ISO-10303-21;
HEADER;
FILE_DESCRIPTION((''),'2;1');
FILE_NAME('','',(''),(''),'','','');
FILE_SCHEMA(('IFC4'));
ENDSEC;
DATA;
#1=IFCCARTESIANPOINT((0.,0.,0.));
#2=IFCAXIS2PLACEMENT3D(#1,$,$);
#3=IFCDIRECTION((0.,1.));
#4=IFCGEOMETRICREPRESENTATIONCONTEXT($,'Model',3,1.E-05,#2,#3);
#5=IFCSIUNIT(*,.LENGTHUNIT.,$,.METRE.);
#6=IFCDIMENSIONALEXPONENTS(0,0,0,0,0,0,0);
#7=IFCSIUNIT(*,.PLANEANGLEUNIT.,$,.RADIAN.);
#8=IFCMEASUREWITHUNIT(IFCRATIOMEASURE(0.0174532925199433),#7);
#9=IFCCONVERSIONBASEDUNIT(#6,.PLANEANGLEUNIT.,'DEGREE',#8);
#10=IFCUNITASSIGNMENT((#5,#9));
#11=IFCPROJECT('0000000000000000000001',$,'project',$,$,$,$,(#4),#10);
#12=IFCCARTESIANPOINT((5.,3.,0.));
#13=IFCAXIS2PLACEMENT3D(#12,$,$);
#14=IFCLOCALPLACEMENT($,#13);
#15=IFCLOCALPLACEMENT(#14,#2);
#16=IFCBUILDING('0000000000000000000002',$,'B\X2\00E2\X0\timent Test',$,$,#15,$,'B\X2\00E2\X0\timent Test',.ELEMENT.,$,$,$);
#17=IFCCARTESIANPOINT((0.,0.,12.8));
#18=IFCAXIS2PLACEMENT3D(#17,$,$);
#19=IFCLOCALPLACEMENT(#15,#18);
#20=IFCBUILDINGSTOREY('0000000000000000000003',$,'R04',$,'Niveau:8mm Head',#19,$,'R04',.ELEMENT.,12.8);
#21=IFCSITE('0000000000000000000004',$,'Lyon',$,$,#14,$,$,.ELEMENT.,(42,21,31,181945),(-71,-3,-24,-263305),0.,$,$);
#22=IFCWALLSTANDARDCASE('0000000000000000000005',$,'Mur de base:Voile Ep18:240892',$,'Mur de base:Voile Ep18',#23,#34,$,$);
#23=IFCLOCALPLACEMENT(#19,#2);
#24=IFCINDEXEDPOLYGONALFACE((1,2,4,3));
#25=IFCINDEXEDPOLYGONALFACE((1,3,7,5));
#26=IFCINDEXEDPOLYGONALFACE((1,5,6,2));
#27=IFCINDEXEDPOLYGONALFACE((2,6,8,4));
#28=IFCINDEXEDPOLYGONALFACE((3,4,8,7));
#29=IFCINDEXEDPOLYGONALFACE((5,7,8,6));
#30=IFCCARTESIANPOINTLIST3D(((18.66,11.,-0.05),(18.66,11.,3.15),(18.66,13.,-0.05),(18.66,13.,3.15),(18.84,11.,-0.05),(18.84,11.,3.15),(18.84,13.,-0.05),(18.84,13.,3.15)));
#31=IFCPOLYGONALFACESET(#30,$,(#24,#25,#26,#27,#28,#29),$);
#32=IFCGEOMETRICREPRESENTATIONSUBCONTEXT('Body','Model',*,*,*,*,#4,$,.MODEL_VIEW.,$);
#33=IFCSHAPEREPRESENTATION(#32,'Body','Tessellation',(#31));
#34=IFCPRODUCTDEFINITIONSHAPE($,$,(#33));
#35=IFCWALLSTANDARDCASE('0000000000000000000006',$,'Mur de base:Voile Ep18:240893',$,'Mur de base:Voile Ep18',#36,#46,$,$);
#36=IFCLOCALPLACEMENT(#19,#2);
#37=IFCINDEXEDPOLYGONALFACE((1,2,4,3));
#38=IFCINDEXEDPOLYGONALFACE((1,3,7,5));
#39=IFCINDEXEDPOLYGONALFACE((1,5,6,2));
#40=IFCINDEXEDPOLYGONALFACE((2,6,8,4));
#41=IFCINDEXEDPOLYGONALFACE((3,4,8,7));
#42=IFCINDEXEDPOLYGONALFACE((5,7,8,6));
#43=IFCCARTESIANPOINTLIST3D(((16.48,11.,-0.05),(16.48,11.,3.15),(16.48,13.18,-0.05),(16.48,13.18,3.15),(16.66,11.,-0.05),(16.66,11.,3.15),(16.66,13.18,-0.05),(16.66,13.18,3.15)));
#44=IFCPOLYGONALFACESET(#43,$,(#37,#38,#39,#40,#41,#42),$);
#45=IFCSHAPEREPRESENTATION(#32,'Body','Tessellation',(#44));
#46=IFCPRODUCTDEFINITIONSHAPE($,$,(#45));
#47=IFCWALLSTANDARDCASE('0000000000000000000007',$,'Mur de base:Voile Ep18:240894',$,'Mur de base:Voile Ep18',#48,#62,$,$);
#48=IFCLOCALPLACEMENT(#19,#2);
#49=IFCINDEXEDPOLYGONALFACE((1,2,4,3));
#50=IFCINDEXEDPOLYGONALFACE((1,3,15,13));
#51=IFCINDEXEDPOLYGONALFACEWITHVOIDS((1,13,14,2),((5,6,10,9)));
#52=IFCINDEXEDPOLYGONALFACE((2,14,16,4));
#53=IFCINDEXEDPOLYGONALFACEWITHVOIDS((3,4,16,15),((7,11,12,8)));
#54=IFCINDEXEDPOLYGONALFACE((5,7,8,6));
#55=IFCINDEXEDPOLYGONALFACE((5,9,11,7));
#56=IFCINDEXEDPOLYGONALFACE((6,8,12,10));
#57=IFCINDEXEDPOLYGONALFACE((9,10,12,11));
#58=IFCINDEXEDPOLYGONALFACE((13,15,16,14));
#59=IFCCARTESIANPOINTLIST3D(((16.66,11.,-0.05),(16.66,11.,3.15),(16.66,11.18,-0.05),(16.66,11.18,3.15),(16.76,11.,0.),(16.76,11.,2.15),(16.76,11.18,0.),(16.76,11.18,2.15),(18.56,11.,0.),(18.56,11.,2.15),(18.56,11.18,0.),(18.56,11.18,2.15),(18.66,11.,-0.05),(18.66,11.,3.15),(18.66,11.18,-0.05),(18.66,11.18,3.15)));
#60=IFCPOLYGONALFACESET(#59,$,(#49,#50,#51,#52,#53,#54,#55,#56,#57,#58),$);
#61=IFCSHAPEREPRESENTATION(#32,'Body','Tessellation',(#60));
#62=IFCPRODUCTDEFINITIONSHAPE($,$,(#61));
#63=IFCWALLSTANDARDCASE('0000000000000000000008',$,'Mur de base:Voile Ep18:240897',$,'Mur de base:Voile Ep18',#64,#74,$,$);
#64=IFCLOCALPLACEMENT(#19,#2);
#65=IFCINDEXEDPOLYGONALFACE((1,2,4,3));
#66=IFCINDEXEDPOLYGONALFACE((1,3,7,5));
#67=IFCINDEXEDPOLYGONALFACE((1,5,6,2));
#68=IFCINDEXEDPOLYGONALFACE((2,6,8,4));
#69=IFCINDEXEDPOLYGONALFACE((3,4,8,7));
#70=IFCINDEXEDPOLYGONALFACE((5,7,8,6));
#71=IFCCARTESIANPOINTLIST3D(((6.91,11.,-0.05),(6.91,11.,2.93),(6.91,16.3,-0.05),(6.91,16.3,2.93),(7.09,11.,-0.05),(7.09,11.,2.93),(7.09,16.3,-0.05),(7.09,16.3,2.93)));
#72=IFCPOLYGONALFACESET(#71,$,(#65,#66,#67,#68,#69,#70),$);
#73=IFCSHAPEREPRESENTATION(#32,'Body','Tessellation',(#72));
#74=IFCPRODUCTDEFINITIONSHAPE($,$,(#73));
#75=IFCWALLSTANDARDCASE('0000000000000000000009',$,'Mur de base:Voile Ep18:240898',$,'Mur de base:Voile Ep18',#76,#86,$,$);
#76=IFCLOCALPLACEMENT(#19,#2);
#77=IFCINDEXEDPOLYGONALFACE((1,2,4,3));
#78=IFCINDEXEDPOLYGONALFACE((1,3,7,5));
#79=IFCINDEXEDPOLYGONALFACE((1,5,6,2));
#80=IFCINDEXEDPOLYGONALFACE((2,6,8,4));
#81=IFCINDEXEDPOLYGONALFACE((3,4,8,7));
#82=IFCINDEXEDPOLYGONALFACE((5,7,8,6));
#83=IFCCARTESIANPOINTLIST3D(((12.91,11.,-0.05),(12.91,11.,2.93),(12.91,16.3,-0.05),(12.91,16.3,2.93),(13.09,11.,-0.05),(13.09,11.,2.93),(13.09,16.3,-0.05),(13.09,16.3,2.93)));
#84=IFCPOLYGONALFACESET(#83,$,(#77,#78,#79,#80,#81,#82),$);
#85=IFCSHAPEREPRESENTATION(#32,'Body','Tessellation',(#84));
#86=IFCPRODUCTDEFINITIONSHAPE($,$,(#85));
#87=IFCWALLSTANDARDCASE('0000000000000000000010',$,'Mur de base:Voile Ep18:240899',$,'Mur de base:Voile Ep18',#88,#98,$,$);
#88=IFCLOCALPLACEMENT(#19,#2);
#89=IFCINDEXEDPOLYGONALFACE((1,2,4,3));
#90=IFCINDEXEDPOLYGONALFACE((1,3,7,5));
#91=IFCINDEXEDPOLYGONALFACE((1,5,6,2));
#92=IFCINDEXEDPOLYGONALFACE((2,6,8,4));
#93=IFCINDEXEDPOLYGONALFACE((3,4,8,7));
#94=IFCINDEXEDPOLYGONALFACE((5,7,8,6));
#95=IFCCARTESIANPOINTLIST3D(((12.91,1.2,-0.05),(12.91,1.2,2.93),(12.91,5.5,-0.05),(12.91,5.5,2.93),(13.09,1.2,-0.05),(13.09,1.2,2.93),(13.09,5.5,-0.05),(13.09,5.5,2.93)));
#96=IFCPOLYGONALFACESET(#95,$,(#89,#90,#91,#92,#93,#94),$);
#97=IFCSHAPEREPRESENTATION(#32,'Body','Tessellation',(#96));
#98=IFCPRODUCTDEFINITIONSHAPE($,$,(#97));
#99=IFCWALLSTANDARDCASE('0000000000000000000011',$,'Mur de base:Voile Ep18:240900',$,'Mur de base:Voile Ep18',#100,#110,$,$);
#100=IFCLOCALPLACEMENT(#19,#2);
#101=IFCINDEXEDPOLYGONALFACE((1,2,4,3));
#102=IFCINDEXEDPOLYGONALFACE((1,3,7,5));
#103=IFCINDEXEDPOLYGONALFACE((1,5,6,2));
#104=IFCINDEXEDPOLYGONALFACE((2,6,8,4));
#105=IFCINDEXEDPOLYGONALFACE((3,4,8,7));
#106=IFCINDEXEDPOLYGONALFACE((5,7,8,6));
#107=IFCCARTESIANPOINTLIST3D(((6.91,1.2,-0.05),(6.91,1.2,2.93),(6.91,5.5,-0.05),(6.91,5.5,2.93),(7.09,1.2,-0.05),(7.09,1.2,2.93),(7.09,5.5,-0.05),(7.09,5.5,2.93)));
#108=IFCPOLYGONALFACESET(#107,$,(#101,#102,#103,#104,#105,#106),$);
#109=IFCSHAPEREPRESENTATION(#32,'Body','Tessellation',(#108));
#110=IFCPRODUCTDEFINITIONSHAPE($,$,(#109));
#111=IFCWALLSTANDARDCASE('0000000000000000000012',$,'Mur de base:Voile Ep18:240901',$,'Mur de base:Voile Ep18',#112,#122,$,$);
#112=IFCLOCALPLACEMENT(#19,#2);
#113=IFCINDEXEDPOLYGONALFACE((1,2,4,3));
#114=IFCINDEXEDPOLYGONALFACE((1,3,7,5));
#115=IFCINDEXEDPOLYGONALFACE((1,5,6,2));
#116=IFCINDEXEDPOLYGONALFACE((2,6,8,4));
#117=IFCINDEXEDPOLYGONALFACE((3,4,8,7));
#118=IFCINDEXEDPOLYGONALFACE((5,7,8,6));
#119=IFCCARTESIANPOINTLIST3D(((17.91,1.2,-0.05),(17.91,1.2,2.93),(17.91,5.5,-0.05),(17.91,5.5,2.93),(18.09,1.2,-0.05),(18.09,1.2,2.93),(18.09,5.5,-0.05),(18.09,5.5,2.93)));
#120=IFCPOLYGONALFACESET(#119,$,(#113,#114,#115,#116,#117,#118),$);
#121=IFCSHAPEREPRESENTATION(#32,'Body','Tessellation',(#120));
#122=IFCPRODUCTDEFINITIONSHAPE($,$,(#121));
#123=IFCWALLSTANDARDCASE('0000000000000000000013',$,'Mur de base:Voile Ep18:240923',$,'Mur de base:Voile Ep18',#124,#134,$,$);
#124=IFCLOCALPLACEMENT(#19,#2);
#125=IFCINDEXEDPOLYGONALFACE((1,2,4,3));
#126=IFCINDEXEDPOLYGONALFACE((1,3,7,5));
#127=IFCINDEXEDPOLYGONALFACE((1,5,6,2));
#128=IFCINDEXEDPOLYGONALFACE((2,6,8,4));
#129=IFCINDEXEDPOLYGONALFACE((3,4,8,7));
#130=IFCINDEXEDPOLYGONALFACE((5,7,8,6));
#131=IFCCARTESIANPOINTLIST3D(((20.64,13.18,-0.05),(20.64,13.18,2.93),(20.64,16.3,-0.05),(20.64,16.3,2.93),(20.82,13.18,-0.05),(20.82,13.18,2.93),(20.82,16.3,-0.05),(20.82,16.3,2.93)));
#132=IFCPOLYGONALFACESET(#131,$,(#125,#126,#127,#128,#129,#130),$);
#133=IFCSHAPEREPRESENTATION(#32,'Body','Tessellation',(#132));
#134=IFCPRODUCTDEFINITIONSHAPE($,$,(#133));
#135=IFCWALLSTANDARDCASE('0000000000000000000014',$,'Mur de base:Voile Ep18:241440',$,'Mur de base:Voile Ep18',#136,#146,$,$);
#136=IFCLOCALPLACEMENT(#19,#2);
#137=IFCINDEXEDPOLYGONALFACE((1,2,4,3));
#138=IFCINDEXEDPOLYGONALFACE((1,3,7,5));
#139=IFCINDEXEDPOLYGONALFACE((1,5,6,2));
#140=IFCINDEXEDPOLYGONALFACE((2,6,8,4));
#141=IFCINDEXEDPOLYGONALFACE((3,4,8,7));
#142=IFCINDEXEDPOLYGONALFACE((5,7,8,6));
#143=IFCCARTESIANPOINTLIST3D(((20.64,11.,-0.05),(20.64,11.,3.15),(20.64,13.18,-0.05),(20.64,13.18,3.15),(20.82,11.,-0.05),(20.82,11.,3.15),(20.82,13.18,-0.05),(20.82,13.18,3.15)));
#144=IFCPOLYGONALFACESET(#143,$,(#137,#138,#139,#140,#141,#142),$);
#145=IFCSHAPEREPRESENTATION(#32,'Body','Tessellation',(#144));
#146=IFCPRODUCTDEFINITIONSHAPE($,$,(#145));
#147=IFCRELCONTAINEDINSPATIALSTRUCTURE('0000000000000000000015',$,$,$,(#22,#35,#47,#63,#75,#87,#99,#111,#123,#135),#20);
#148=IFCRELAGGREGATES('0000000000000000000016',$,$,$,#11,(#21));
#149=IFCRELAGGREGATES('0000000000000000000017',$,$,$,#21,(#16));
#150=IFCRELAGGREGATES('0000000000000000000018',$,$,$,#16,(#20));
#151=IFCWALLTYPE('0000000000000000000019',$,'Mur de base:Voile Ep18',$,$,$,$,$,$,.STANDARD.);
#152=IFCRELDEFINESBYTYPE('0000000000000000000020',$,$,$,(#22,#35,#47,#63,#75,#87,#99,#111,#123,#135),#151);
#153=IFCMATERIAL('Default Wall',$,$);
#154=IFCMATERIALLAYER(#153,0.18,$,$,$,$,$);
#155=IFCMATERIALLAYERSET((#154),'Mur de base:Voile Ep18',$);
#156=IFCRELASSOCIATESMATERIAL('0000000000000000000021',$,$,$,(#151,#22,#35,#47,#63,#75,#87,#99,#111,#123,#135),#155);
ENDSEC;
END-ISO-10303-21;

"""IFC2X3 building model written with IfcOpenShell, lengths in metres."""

from ifc_helpers import new_model, entity, si_unit, converted_unit, direction, frame, frame_2d, origin, place, context, subcontext, project, spatial, rectangle, extrude, material, layer, layer_set, layer_usage, type_object, element, save


model = new_model("IFC2X3")

# Units and contexts
model_context = context("Model", 3, precision=1e-05, world=origin(), true_north=direction((0.0, 1.0)))
body_context = subcontext(model_context, "Body", "Model", "MODEL_VIEW")
ifc_project = project(units=[si_unit("LENGTHUNIT", "METRE"), converted_unit("PLANEANGLEUNIT", "DEGREE", entity("IfcRatioMeasure", 0.0174532925199433), si_unit("PLANEANGLEUNIT", "RADIAN"), dimensions=[0, 0, 0, 0, 0, 0, 0])], contexts=[model_context])

# Site, building, storey
site_placement = place(None, frame((5.0, 3.0, 0.0)))
site = spatial("IfcSite", under=ifc_project, at=site_placement, Name="Lyon", CompositionType="ELEMENT", RefLatitude=(42, 21, 31, 181945), RefLongitude=(-71, -3, -24, -263305), RefElevation=0.0)
building_placement = place(site_placement, origin())
building = spatial("IfcBuilding", under=site, at=building_placement, Name="Bâtiment Test", LongName="Bâtiment Test", CompositionType="ELEMENT")
storey_placement = place(building_placement, frame((0.0, 0.0, 12.8)))
storey = spatial("IfcBuildingStorey", under=building, at=storey_placement, Name="R04", ObjectType="Niveau:8mm Head", LongName="R04", CompositionType="ELEMENT", Elevation=12.8)

# Shared definitions
ifc_material_1 = material(Name="Default Wall")

# Walls
ifc_layer_1 = layer(ifc_material_1, 0.18)
ifc_layer_set_1 = layer_set([ifc_layer_1], Name="Mur de base:Voile Ep18")
wall_type_1 = type_object("IfcWallType", Name="Mur de base:Voile Ep18", PredefinedType="STANDARD", material=ifc_layer_set_1)
ifc_layer_usage_1 = layer_usage(ifc_layer_set_1, "AXIS2", "NEGATIVE", 0.09)
wall_1_placement = place(storey_placement, frame((18.75, 13.0, -0.05), z_axis=(0.0, 0.0, 1.0), x_axis=(0.0, -1.0, 0.0)))
element("IfcWallStandardCase", 1, at=wall_1_placement, inside=storey, type_object=wall_type_1, material=ifc_layer_usage_1, Name="Mur de base:Voile Ep18:240892", ObjectType="Mur de base:Voile Ep18", context=body_context, shape_type="SweptSolid", body=[
    extrude(rectangle(XDim=2.0, YDim=0.18, at=frame_2d((1.0, 0.0), x_axis=(-1.0, 0.0))), origin(), (0.0, 0.0, 1.0), 3.2),
])
ifc_layer_usage_2 = layer_usage(ifc_layer_set_1, "AXIS2", "NEGATIVE", 0.09)
wall_2_placement = place(storey_placement, frame((16.57, 13.18, -0.05), z_axis=(0.0, 0.0, 1.0), x_axis=(0.0, -1.0, 0.0)))
element("IfcWallStandardCase", 2, at=wall_2_placement, inside=storey, type_object=wall_type_1, material=ifc_layer_usage_2, Name="Mur de base:Voile Ep18:240893", ObjectType="Mur de base:Voile Ep18", context=body_context, shape_type="SweptSolid", body=[
    extrude(rectangle(XDim=2.18, YDim=0.18, at=frame_2d((1.09, 0.0), x_axis=(-1.0, 0.0))), origin(), (0.0, 0.0, 1.0), 3.2),
])

# Wall, opening
ifc_layer_usage_3 = layer_usage(ifc_layer_set_1, "AXIS2", "POSITIVE", -0.09)
wall_3_placement = place(storey_placement, frame((16.66, 11.09, -0.05)))
wall_3 = element("IfcWallStandardCase", 3, at=wall_3_placement, inside=storey, type_object=wall_type_1, material=ifc_layer_usage_3, Name="Mur de base:Voile Ep18:240894", ObjectType="Mur de base:Voile Ep18", context=body_context, shape_type="SweptSolid", body=[
    extrude(rectangle(XDim=2.0, YDim=0.18, at=frame_2d((1.0, 0.0), x_axis=(-1.0, 0.0))), origin(), (0.0, 0.0, 1.0), 3.2),
])
opening_1_placement = place(wall_3_placement, origin())
element("IfcOpeningElement", 4, at=opening_1_placement, cuts=wall_3, ObjectType="Opening", context=body_context, shape_type="SweptSolid", body=[
    extrude(rectangle(XDim=2.15, YDim=1.8, at=frame_2d((0.0, 0.0), x_axis=(0.0, 1.0))), frame((1.0, -0.09, 1.125), z_axis=(0.0, 1.0, 0.0), x_axis=(1.0, 0.0, 0.0)), (0.0, 0.0, 1.0), 0.18),
])

# Walls
ifc_layer_usage_4 = layer_usage(ifc_layer_set_1, "AXIS2", "NEGATIVE", 0.09)
wall_4_placement = place(storey_placement, frame((7.0, 16.3, -0.05), z_axis=(0.0, 0.0, 1.0), x_axis=(0.0, -1.0, 0.0)))
element("IfcWallStandardCase", 5, at=wall_4_placement, inside=storey, type_object=wall_type_1, material=ifc_layer_usage_4, Name="Mur de base:Voile Ep18:240897", ObjectType="Mur de base:Voile Ep18", context=body_context, shape_type="SweptSolid", body=[
    extrude(rectangle(XDim=5.3, YDim=0.18, at=frame_2d((2.65, 0.0), x_axis=(-1.0, 0.0))), origin(), (0.0, 0.0, 1.0), 2.98),
])
ifc_layer_usage_5 = layer_usage(ifc_layer_set_1, "AXIS2", "NEGATIVE", 0.09)
wall_5_placement = place(storey_placement, frame((13.0, 16.3, -0.05), z_axis=(0.0, 0.0, 1.0), x_axis=(0.0, -1.0, 0.0)))
element("IfcWallStandardCase", 6, at=wall_5_placement, inside=storey, type_object=wall_type_1, material=ifc_layer_usage_5, Name="Mur de base:Voile Ep18:240898", ObjectType="Mur de base:Voile Ep18", context=body_context, shape_type="SweptSolid", body=[
    extrude(rectangle(XDim=5.3, YDim=0.18, at=frame_2d((2.65, 0.0), x_axis=(-1.0, 0.0))), origin(), (0.0, 0.0, 1.0), 2.98),
])
ifc_layer_usage_6 = layer_usage(ifc_layer_set_1, "AXIS2", "NEGATIVE", 0.09)
wall_6_placement = place(storey_placement, frame((13.0, 1.2, -0.05), z_axis=(0.0, 0.0, 1.0), x_axis=(0.0, 1.0, 0.0)))
element("IfcWallStandardCase", 7, at=wall_6_placement, inside=storey, type_object=wall_type_1, material=ifc_layer_usage_6, Name="Mur de base:Voile Ep18:240899", ObjectType="Mur de base:Voile Ep18", context=body_context, shape_type="SweptSolid", body=[
    extrude(rectangle(XDim=4.3, YDim=0.18, at=frame_2d((2.15, 0.0), x_axis=(-1.0, 0.0))), origin(), (0.0, 0.0, 1.0), 2.98),
])
ifc_layer_usage_7 = layer_usage(ifc_layer_set_1, "AXIS2", "NEGATIVE", 0.09)
wall_7_placement = place(storey_placement, frame((7.0, 1.2, -0.05), z_axis=(0.0, 0.0, 1.0), x_axis=(0.0, 1.0, 0.0)))
element("IfcWallStandardCase", 8, at=wall_7_placement, inside=storey, type_object=wall_type_1, material=ifc_layer_usage_7, Name="Mur de base:Voile Ep18:240900", ObjectType="Mur de base:Voile Ep18", context=body_context, shape_type="SweptSolid", body=[
    extrude(rectangle(XDim=4.3, YDim=0.18, at=frame_2d((2.15, 0.0), x_axis=(-1.0, 0.0))), origin(), (0.0, 0.0, 1.0), 2.98),
])
ifc_layer_usage_8 = layer_usage(ifc_layer_set_1, "AXIS2", "NEGATIVE", 0.09)
wall_8_placement = place(storey_placement, frame((18.0, 1.2, -0.05), z_axis=(0.0, 0.0, 1.0), x_axis=(0.0, 1.0, 0.0)))
element("IfcWallStandardCase", 9, at=wall_8_placement, inside=storey, type_object=wall_type_1, material=ifc_layer_usage_8, Name="Mur de base:Voile Ep18:240901", ObjectType="Mur de base:Voile Ep18", context=body_context, shape_type="SweptSolid", body=[
    extrude(rectangle(XDim=4.3, YDim=0.18, at=frame_2d((2.15, 0.0), x_axis=(-1.0, 0.0))), origin(), (0.0, 0.0, 1.0), 2.98),
])
ifc_layer_usage_9 = layer_usage(ifc_layer_set_1, "AXIS2", "NEGATIVE", 0.09)
wall_9_placement = place(storey_placement, frame((20.73, 16.3, -0.05), z_axis=(0.0, 0.0, 1.0), x_axis=(0.0, -1.0, 0.0)))
element("IfcWallStandardCase", 10, at=wall_9_placement, inside=storey, type_object=wall_type_1, material=ifc_layer_usage_9, Name="Mur de base:Voile Ep18:240923", ObjectType="Mur de base:Voile Ep18", context=body_context, shape_type="SweptSolid", body=[
    extrude(rectangle(XDim=3.12, YDim=0.18, at=frame_2d((1.56, 0.0), x_axis=(-1.0, 0.0))), origin(), (0.0, 0.0, 1.0), 2.98),
])
ifc_layer_usage_10 = layer_usage(ifc_layer_set_1, "AXIS2", "NEGATIVE", 0.09)
wall_10_placement = place(storey_placement, frame((20.73, 13.18, -0.05), z_axis=(0.0, 0.0, 1.0), x_axis=(0.0, -1.0, 0.0)))
element("IfcWallStandardCase", 11, at=wall_10_placement, inside=storey, type_object=wall_type_1, material=ifc_layer_usage_10, Name="Mur de base:Voile Ep18:241440", ObjectType="Mur de base:Voile Ep18", context=body_context, shape_type="SweptSolid", body=[
    extrude(rectangle(XDim=2.18, YDim=0.18, at=frame_2d((1.09, 0.0), x_axis=(-1.0, 0.0))), origin(), (0.0, 0.0, 1.0), 3.2),
])

save(model, "model.ifc")
